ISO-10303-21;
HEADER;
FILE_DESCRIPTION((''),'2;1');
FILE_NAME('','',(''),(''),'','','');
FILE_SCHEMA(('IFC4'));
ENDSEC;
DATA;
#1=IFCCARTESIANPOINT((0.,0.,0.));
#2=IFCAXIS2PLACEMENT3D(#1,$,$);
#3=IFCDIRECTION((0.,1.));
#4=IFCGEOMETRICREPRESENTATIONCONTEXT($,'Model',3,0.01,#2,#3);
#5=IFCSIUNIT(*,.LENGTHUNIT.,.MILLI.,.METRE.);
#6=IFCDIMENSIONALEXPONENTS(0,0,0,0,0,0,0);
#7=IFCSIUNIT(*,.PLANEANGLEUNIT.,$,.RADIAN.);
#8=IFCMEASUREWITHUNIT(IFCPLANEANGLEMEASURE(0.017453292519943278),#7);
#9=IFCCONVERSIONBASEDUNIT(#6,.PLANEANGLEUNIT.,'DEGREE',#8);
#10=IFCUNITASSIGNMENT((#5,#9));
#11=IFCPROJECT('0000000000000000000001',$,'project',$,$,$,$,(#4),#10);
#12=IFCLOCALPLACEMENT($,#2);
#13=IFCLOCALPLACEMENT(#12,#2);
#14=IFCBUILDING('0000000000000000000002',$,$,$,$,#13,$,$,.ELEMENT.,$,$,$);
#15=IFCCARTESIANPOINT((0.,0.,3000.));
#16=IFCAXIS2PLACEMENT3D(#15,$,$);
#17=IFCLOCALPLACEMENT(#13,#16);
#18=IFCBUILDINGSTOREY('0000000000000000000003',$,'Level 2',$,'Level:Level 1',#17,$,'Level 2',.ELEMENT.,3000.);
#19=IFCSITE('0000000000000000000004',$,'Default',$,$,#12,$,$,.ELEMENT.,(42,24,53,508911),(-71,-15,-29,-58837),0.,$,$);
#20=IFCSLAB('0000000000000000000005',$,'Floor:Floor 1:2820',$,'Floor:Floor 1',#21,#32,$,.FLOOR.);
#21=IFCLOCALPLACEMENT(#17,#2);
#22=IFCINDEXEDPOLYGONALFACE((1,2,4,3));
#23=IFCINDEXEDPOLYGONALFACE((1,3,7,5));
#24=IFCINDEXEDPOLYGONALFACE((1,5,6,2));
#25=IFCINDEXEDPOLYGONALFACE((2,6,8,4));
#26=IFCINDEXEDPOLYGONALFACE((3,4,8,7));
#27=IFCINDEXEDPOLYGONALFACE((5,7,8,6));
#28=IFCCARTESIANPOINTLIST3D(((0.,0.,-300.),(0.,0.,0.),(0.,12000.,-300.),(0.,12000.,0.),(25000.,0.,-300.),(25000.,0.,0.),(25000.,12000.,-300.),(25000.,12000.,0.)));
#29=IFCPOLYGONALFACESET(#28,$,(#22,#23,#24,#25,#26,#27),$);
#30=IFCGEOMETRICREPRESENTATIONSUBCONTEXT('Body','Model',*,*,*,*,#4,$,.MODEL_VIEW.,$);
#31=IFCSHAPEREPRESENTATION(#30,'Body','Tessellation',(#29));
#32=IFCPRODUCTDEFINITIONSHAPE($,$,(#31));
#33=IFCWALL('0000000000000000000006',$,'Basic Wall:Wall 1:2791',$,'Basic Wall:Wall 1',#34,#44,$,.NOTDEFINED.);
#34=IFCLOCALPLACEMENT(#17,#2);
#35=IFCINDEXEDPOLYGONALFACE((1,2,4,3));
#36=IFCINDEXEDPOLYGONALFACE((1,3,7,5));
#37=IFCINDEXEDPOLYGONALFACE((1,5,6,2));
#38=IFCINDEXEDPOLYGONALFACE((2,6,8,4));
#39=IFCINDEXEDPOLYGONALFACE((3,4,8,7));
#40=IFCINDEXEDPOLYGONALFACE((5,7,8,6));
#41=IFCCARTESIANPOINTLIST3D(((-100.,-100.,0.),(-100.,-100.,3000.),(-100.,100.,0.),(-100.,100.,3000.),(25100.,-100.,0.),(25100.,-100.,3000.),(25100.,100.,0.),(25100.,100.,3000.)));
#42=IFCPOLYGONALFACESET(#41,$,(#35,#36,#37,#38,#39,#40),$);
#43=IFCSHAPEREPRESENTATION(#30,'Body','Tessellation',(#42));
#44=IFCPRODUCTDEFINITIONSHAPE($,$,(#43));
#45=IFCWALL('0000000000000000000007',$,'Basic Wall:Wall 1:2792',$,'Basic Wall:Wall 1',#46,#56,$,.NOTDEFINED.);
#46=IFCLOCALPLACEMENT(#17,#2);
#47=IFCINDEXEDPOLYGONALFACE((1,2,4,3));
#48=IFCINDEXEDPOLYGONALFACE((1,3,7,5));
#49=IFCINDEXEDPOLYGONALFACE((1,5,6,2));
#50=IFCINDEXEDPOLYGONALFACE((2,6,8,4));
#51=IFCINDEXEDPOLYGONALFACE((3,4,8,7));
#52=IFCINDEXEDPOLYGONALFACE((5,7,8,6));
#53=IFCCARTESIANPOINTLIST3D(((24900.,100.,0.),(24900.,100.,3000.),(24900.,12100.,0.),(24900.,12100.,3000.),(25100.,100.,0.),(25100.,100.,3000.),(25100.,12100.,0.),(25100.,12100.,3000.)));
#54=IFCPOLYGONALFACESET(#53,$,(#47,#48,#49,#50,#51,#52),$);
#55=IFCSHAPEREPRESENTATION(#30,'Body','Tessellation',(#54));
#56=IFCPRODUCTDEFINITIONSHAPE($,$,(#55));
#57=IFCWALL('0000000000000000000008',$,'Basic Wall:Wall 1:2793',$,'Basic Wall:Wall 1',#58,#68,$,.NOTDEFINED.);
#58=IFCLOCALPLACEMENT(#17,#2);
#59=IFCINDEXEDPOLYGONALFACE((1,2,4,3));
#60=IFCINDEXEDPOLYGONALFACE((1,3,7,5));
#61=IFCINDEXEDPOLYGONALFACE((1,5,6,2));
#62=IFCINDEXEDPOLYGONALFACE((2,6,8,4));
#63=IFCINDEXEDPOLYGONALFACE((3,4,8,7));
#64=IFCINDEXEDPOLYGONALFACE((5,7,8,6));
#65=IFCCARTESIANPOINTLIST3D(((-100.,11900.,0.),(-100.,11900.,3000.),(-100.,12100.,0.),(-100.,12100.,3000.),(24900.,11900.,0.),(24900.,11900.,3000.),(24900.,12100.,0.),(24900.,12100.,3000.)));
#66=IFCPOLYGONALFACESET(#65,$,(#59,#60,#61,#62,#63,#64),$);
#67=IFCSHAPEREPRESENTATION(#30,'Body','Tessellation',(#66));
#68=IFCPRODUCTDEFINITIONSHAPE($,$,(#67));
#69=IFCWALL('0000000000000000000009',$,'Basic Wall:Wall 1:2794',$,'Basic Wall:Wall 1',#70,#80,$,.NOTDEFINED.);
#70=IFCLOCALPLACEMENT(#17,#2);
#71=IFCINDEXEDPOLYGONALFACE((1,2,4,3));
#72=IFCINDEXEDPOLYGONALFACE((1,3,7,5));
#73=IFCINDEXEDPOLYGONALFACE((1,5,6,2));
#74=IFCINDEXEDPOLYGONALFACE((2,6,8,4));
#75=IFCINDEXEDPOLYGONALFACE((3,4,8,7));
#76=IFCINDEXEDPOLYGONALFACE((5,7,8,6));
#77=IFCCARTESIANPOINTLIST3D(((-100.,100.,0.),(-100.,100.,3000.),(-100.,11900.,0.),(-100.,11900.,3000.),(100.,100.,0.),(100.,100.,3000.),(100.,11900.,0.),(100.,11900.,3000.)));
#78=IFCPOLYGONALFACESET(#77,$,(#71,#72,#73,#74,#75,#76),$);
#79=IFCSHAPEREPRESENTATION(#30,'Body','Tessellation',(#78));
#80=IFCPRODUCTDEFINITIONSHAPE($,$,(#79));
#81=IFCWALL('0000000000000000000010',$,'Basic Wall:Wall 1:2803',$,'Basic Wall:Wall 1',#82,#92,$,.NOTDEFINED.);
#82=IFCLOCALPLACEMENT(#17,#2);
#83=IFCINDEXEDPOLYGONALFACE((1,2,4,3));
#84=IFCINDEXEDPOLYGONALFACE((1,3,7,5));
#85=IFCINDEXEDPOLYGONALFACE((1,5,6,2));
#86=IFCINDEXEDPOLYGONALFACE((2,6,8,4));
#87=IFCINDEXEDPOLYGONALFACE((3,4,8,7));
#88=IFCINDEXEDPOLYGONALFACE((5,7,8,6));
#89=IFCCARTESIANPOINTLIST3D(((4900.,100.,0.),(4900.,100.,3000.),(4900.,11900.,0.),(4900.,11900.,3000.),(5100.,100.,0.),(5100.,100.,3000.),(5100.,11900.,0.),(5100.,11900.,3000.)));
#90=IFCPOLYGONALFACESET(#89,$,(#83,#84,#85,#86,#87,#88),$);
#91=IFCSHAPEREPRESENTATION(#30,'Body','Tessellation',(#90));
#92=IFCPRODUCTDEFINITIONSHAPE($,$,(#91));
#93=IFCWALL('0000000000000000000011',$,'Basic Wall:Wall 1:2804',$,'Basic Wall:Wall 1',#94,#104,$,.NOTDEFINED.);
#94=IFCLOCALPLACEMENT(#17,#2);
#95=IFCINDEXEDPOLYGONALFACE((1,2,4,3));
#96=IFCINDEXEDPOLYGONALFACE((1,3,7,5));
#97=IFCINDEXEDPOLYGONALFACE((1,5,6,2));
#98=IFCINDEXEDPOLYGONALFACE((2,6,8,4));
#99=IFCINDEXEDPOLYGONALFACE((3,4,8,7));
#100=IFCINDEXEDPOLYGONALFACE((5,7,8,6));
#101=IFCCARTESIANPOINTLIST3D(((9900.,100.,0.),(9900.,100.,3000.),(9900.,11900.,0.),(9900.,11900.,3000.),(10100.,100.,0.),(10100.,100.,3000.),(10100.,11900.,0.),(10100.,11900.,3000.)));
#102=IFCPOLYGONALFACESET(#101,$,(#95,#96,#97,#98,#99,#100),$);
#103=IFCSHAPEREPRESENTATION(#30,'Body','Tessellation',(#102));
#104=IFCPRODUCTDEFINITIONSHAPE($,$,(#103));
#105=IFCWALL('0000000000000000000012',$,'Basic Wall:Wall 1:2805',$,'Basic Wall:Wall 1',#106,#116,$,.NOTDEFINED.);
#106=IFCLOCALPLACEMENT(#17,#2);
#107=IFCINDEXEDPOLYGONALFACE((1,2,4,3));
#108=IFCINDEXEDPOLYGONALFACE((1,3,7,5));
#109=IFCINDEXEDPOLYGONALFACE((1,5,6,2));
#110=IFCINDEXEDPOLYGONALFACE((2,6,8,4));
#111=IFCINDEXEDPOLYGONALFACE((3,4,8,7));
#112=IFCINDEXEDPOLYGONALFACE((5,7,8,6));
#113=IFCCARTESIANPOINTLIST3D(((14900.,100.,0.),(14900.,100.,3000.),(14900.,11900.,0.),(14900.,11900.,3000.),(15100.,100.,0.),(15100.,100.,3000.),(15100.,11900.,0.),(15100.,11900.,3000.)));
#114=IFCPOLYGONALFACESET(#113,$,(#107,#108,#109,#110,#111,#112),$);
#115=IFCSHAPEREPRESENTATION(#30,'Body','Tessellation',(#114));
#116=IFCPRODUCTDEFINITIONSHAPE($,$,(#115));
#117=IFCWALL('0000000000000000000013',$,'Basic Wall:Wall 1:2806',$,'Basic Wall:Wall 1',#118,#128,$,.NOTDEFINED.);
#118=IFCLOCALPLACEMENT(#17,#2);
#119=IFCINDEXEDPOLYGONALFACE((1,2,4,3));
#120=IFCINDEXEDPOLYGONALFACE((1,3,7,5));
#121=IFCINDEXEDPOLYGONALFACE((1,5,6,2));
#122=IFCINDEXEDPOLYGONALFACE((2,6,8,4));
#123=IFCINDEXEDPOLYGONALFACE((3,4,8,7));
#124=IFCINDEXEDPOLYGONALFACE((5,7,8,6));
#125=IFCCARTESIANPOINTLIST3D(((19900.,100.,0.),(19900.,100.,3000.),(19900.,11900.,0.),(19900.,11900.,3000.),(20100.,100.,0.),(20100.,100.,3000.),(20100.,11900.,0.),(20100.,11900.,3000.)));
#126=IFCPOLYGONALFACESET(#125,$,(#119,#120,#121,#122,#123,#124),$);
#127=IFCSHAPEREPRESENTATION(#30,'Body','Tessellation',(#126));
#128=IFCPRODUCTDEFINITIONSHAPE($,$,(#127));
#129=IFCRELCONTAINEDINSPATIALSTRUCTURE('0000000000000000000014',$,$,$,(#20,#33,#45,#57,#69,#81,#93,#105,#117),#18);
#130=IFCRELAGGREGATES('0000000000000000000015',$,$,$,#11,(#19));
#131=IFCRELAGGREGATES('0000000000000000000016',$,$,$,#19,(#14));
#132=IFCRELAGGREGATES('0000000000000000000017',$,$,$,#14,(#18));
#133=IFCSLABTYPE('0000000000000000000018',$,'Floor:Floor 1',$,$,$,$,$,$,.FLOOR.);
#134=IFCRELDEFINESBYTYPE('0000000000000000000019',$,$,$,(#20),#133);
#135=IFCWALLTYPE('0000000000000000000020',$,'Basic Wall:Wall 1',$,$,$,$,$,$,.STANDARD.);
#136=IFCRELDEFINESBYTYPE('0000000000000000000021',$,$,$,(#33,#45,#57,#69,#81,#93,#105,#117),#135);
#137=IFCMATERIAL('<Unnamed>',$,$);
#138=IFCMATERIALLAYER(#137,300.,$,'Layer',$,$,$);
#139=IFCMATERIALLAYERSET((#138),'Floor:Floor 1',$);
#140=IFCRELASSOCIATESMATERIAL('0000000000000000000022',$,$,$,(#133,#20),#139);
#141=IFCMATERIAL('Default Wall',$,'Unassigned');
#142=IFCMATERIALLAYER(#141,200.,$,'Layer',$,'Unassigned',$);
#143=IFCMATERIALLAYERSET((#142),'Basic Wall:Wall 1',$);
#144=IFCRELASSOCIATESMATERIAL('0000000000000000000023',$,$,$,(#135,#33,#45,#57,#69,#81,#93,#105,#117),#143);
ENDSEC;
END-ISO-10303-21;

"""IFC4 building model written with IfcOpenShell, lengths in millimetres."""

from ifc_helpers import new_model, entity, si_unit, converted_unit, direction, frame, frame_2d, origin, origin_2d_with_axis, place, context, subcontext, project, spatial, rectangle, extrude, material, layer, layer_set, layer_usage, type_object, element, save


model = new_model("IFC4")

# Units and contexts
model_context = context("Model", 3, precision=0.01, world=origin(), true_north=direction((0.0, 1.0)))
body_context = subcontext(model_context, "Body", "Model", "MODEL_VIEW")
ifc_project = project(units=[si_unit("LENGTHUNIT", "METRE", prefix="MILLI"), converted_unit("PLANEANGLEUNIT", "DEGREE", entity("IfcPlaneAngleMeasure", 0.017453292519943278), si_unit("PLANEANGLEUNIT", "RADIAN"), dimensions=[0, 0, 0, 0, 0, 0, 0])], contexts=[model_context])

# Site, building, storey
site_placement = place(None, origin())
site = spatial("IfcSite", under=ifc_project, at=site_placement, Name="Default", CompositionType="ELEMENT", RefLatitude=(42, 24, 53, 508911), RefLongitude=(-71, -15, -29, -58837), RefElevation=0.0)
building_placement = place(site_placement, origin())
building = spatial("IfcBuilding", under=site, at=building_placement, CompositionType="ELEMENT")
storey_placement = place(building_placement, frame((0.0, 0.0, 3000.0)))
storey = spatial("IfcBuildingStorey", under=building, at=storey_placement, Name="Level 2", ObjectType="Level:Level 1", LongName="Level 2", CompositionType="ELEMENT", Elevation=3000.0)

# Slab
ifc_material_1 = material(Name="<Unnamed>")
ifc_layer_1 = layer(ifc_material_1, 300.0, Name="Layer")
ifc_layer_set_1 = layer_set([ifc_layer_1], Name="Floor:Floor 1")
ifc_layer_usage_1 = layer_usage(ifc_layer_set_1, "AXIS3", "POSITIVE", 0.0)
slab_type = type_object("IfcSlabType", Name="Floor:Floor 1", PredefinedType="FLOOR", material=ifc_layer_set_1)
slab_placement = place(storey_placement, origin())
element("IfcSlab", 1, at=slab_placement, inside=storey, type_object=slab_type, material=ifc_layer_usage_1, Name="Floor:Floor 1:2820", ObjectType="Floor:Floor 1", PredefinedType="FLOOR", context=body_context, shape_type="SweptSolid", body=[
    extrude(rectangle(XDim=12000.0, YDim=25000.0, at=origin_2d_with_axis()), frame((12500.0, 6000.0, 0.0), z_axis=(0.0, 0.0, -1.0), x_axis=(0.0, 1.0, 0.0)), (0.0, 0.0, 1.0), 300.0),
])

# Walls
ifc_material_2 = material(Name="Default Wall", Category="Unassigned")
ifc_layer_2 = layer(ifc_material_2, 200.0, Name="Layer", Category="Unassigned")
ifc_layer_set_2 = layer_set([ifc_layer_2], Name="Basic Wall:Wall 1")
ifc_layer_usage_2 = layer_usage(ifc_layer_set_2, "AXIS2", "NEGATIVE", 100.0)
wall_type = type_object("IfcWallType", Name="Basic Wall:Wall 1", PredefinedType="STANDARD", material=ifc_layer_set_2)
wall_1_placement = place(storey_placement, frame((-100.0, 0.0, 0.0)))
element("IfcWall", 2, at=wall_1_placement, inside=storey, type_object=wall_type, material=ifc_layer_usage_2, Name="Basic Wall:Wall 1:2791", ObjectType="Basic Wall:Wall 1", PredefinedType="NOTDEFINED", context=body_context, shape_type="SweptSolid", body=[
    extrude(rectangle(XDim=25200.0, YDim=200.0, at=frame_2d((12600.0, 0.0), x_axis=(-1.0, 0.0))), origin(), (0.0, 0.0, 1.0), 3000.0),
])
ifc_layer_usage_3 = layer_usage(ifc_layer_set_2, "AXIS2", "NEGATIVE", 100.0)
wall_2_placement = place(storey_placement, frame((25000.0, 100.0, 0.0), z_axis=(0.0, 0.0, 1.0), x_axis=(0.0, 1.0, 0.0)))
element("IfcWall", 3, at=wall_2_placement, inside=storey, type_object=wall_type, material=ifc_layer_usage_3, Name="Basic Wall:Wall 1:2792", ObjectType="Basic Wall:Wall 1", PredefinedType="NOTDEFINED", context=body_context, shape_type="SweptSolid", body=[
    extrude(rectangle(XDim=12000.0, YDim=200.0, at=frame_2d((6000.0, 0.0), x_axis=(-1.0, 0.0))), origin(), (0.0, 0.0, 1.0), 3000.0),
])
ifc_layer_usage_4 = layer_usage(ifc_layer_set_2, "AXIS2", "NEGATIVE", 100.0)
wall_3_placement = place(storey_placement, frame((24900.0, 12000.0, 0.0), z_axis=(0.0, 0.0, 1.0), x_axis=(-1.0, 0.0, 0.0)))
element("IfcWall", 4, at=wall_3_placement, inside=storey, type_object=wall_type, material=ifc_layer_usage_4, Name="Basic Wall:Wall 1:2793", ObjectType="Basic Wall:Wall 1", PredefinedType="NOTDEFINED", context=body_context, shape_type="SweptSolid", body=[
    extrude(rectangle(XDim=25000.0, YDim=200.0, at=frame_2d((12500.0, 0.0), x_axis=(-1.0, 0.0))), origin(), (0.0, 0.0, 1.0), 3000.0),
])
ifc_layer_usage_5 = layer_usage(ifc_layer_set_2, "AXIS2", "NEGATIVE", 100.0)
wall_4_placement = place(storey_placement, frame((0.0, 11900.0, 0.0), z_axis=(0.0, 0.0, 1.0), x_axis=(0.0, -1.0, 0.0)))
element("IfcWall", 5, at=wall_4_placement, inside=storey, type_object=wall_type, material=ifc_layer_usage_5, Name="Basic Wall:Wall 1:2794", ObjectType="Basic Wall:Wall 1", PredefinedType="NOTDEFINED", context=body_context, shape_type="SweptSolid", body=[
    extrude(rectangle(XDim=11800.0, YDim=200.0, at=frame_2d((5900.0, 0.0), x_axis=(-1.0, 0.0))), origin(), (0.0, 0.0, 1.0), 3000.0),
])
ifc_layer_usage_6 = layer_usage(ifc_layer_set_2, "AXIS2", "NEGATIVE", 100.0)
wall_5_placement = place(storey_placement, frame((5000.0, 100.0, 0.0), z_axis=(0.0, 0.0, 1.0), x_axis=(0.0, 1.0, 0.0)))
element("IfcWall", 6, at=wall_5_placement, inside=storey, type_object=wall_type, material=ifc_layer_usage_6, Name="Basic Wall:Wall 1:2803", ObjectType="Basic Wall:Wall 1", PredefinedType="NOTDEFINED", context=body_context, shape_type="SweptSolid", body=[
    extrude(rectangle(XDim=11800.0, YDim=200.0, at=frame_2d((5900.0, 0.0), x_axis=(-1.0, 0.0))), origin(), (0.0, 0.0, 1.0), 3000.0),
])
ifc_layer_usage_7 = layer_usage(ifc_layer_set_2, "AXIS2", "NEGATIVE", 100.0)
wall_6_placement = place(storey_placement, frame((10000.0, 100.0, 0.0), z_axis=(0.0, 0.0, 1.0), x_axis=(0.0, 1.0, 0.0)))
element("IfcWall", 7, at=wall_6_placement, inside=storey, type_object=wall_type, material=ifc_layer_usage_7, Name="Basic Wall:Wall 1:2804", ObjectType="Basic Wall:Wall 1", PredefinedType="NOTDEFINED", context=body_context, shape_type="SweptSolid", body=[
    extrude(rectangle(XDim=11800.0, YDim=200.0, at=frame_2d((5900.0, 0.0), x_axis=(-1.0, 0.0))), origin(), (0.0, 0.0, 1.0), 3000.0),
])
ifc_layer_usage_8 = layer_usage(ifc_layer_set_2, "AXIS2", "NEGATIVE", 100.0)
wall_7_placement = place(storey_placement, frame((15000.0, 100.0, 0.0), z_axis=(0.0, 0.0, 1.0), x_axis=(0.0, 1.0, 0.0)))
element("IfcWall", 8, at=wall_7_placement, inside=storey, type_object=wall_type, material=ifc_layer_usage_8, Name="Basic Wall:Wall 1:2805", ObjectType="Basic Wall:Wall 1", PredefinedType="NOTDEFINED", context=body_context, shape_type="SweptSolid", body=[
    extrude(rectangle(XDim=11800.0, YDim=200.0, at=frame_2d((5900.0, 0.0), x_axis=(-1.0, 0.0))), origin(), (0.0, 0.0, 1.0), 3000.0),
])
ifc_layer_usage_9 = layer_usage(ifc_layer_set_2, "AXIS2", "NEGATIVE", 100.0)
wall_8_placement = place(storey_placement, frame((20000.0, 100.0, 0.0), z_axis=(0.0, 0.0, 1.0), x_axis=(0.0, 1.0, 0.0)))
element("IfcWall", 9, at=wall_8_placement, inside=storey, type_object=wall_type, material=ifc_layer_usage_9, Name="Basic Wall:Wall 1:2806", ObjectType="Basic Wall:Wall 1", PredefinedType="NOTDEFINED", context=body_context, shape_type="SweptSolid", body=[
    extrude(rectangle(XDim=11800.0, YDim=200.0, at=frame_2d((5900.0, 0.0), x_axis=(-1.0, 0.0))), origin(), (0.0, 0.0, 1.0), 3000.0),
])

save(model, "model.ifc")
